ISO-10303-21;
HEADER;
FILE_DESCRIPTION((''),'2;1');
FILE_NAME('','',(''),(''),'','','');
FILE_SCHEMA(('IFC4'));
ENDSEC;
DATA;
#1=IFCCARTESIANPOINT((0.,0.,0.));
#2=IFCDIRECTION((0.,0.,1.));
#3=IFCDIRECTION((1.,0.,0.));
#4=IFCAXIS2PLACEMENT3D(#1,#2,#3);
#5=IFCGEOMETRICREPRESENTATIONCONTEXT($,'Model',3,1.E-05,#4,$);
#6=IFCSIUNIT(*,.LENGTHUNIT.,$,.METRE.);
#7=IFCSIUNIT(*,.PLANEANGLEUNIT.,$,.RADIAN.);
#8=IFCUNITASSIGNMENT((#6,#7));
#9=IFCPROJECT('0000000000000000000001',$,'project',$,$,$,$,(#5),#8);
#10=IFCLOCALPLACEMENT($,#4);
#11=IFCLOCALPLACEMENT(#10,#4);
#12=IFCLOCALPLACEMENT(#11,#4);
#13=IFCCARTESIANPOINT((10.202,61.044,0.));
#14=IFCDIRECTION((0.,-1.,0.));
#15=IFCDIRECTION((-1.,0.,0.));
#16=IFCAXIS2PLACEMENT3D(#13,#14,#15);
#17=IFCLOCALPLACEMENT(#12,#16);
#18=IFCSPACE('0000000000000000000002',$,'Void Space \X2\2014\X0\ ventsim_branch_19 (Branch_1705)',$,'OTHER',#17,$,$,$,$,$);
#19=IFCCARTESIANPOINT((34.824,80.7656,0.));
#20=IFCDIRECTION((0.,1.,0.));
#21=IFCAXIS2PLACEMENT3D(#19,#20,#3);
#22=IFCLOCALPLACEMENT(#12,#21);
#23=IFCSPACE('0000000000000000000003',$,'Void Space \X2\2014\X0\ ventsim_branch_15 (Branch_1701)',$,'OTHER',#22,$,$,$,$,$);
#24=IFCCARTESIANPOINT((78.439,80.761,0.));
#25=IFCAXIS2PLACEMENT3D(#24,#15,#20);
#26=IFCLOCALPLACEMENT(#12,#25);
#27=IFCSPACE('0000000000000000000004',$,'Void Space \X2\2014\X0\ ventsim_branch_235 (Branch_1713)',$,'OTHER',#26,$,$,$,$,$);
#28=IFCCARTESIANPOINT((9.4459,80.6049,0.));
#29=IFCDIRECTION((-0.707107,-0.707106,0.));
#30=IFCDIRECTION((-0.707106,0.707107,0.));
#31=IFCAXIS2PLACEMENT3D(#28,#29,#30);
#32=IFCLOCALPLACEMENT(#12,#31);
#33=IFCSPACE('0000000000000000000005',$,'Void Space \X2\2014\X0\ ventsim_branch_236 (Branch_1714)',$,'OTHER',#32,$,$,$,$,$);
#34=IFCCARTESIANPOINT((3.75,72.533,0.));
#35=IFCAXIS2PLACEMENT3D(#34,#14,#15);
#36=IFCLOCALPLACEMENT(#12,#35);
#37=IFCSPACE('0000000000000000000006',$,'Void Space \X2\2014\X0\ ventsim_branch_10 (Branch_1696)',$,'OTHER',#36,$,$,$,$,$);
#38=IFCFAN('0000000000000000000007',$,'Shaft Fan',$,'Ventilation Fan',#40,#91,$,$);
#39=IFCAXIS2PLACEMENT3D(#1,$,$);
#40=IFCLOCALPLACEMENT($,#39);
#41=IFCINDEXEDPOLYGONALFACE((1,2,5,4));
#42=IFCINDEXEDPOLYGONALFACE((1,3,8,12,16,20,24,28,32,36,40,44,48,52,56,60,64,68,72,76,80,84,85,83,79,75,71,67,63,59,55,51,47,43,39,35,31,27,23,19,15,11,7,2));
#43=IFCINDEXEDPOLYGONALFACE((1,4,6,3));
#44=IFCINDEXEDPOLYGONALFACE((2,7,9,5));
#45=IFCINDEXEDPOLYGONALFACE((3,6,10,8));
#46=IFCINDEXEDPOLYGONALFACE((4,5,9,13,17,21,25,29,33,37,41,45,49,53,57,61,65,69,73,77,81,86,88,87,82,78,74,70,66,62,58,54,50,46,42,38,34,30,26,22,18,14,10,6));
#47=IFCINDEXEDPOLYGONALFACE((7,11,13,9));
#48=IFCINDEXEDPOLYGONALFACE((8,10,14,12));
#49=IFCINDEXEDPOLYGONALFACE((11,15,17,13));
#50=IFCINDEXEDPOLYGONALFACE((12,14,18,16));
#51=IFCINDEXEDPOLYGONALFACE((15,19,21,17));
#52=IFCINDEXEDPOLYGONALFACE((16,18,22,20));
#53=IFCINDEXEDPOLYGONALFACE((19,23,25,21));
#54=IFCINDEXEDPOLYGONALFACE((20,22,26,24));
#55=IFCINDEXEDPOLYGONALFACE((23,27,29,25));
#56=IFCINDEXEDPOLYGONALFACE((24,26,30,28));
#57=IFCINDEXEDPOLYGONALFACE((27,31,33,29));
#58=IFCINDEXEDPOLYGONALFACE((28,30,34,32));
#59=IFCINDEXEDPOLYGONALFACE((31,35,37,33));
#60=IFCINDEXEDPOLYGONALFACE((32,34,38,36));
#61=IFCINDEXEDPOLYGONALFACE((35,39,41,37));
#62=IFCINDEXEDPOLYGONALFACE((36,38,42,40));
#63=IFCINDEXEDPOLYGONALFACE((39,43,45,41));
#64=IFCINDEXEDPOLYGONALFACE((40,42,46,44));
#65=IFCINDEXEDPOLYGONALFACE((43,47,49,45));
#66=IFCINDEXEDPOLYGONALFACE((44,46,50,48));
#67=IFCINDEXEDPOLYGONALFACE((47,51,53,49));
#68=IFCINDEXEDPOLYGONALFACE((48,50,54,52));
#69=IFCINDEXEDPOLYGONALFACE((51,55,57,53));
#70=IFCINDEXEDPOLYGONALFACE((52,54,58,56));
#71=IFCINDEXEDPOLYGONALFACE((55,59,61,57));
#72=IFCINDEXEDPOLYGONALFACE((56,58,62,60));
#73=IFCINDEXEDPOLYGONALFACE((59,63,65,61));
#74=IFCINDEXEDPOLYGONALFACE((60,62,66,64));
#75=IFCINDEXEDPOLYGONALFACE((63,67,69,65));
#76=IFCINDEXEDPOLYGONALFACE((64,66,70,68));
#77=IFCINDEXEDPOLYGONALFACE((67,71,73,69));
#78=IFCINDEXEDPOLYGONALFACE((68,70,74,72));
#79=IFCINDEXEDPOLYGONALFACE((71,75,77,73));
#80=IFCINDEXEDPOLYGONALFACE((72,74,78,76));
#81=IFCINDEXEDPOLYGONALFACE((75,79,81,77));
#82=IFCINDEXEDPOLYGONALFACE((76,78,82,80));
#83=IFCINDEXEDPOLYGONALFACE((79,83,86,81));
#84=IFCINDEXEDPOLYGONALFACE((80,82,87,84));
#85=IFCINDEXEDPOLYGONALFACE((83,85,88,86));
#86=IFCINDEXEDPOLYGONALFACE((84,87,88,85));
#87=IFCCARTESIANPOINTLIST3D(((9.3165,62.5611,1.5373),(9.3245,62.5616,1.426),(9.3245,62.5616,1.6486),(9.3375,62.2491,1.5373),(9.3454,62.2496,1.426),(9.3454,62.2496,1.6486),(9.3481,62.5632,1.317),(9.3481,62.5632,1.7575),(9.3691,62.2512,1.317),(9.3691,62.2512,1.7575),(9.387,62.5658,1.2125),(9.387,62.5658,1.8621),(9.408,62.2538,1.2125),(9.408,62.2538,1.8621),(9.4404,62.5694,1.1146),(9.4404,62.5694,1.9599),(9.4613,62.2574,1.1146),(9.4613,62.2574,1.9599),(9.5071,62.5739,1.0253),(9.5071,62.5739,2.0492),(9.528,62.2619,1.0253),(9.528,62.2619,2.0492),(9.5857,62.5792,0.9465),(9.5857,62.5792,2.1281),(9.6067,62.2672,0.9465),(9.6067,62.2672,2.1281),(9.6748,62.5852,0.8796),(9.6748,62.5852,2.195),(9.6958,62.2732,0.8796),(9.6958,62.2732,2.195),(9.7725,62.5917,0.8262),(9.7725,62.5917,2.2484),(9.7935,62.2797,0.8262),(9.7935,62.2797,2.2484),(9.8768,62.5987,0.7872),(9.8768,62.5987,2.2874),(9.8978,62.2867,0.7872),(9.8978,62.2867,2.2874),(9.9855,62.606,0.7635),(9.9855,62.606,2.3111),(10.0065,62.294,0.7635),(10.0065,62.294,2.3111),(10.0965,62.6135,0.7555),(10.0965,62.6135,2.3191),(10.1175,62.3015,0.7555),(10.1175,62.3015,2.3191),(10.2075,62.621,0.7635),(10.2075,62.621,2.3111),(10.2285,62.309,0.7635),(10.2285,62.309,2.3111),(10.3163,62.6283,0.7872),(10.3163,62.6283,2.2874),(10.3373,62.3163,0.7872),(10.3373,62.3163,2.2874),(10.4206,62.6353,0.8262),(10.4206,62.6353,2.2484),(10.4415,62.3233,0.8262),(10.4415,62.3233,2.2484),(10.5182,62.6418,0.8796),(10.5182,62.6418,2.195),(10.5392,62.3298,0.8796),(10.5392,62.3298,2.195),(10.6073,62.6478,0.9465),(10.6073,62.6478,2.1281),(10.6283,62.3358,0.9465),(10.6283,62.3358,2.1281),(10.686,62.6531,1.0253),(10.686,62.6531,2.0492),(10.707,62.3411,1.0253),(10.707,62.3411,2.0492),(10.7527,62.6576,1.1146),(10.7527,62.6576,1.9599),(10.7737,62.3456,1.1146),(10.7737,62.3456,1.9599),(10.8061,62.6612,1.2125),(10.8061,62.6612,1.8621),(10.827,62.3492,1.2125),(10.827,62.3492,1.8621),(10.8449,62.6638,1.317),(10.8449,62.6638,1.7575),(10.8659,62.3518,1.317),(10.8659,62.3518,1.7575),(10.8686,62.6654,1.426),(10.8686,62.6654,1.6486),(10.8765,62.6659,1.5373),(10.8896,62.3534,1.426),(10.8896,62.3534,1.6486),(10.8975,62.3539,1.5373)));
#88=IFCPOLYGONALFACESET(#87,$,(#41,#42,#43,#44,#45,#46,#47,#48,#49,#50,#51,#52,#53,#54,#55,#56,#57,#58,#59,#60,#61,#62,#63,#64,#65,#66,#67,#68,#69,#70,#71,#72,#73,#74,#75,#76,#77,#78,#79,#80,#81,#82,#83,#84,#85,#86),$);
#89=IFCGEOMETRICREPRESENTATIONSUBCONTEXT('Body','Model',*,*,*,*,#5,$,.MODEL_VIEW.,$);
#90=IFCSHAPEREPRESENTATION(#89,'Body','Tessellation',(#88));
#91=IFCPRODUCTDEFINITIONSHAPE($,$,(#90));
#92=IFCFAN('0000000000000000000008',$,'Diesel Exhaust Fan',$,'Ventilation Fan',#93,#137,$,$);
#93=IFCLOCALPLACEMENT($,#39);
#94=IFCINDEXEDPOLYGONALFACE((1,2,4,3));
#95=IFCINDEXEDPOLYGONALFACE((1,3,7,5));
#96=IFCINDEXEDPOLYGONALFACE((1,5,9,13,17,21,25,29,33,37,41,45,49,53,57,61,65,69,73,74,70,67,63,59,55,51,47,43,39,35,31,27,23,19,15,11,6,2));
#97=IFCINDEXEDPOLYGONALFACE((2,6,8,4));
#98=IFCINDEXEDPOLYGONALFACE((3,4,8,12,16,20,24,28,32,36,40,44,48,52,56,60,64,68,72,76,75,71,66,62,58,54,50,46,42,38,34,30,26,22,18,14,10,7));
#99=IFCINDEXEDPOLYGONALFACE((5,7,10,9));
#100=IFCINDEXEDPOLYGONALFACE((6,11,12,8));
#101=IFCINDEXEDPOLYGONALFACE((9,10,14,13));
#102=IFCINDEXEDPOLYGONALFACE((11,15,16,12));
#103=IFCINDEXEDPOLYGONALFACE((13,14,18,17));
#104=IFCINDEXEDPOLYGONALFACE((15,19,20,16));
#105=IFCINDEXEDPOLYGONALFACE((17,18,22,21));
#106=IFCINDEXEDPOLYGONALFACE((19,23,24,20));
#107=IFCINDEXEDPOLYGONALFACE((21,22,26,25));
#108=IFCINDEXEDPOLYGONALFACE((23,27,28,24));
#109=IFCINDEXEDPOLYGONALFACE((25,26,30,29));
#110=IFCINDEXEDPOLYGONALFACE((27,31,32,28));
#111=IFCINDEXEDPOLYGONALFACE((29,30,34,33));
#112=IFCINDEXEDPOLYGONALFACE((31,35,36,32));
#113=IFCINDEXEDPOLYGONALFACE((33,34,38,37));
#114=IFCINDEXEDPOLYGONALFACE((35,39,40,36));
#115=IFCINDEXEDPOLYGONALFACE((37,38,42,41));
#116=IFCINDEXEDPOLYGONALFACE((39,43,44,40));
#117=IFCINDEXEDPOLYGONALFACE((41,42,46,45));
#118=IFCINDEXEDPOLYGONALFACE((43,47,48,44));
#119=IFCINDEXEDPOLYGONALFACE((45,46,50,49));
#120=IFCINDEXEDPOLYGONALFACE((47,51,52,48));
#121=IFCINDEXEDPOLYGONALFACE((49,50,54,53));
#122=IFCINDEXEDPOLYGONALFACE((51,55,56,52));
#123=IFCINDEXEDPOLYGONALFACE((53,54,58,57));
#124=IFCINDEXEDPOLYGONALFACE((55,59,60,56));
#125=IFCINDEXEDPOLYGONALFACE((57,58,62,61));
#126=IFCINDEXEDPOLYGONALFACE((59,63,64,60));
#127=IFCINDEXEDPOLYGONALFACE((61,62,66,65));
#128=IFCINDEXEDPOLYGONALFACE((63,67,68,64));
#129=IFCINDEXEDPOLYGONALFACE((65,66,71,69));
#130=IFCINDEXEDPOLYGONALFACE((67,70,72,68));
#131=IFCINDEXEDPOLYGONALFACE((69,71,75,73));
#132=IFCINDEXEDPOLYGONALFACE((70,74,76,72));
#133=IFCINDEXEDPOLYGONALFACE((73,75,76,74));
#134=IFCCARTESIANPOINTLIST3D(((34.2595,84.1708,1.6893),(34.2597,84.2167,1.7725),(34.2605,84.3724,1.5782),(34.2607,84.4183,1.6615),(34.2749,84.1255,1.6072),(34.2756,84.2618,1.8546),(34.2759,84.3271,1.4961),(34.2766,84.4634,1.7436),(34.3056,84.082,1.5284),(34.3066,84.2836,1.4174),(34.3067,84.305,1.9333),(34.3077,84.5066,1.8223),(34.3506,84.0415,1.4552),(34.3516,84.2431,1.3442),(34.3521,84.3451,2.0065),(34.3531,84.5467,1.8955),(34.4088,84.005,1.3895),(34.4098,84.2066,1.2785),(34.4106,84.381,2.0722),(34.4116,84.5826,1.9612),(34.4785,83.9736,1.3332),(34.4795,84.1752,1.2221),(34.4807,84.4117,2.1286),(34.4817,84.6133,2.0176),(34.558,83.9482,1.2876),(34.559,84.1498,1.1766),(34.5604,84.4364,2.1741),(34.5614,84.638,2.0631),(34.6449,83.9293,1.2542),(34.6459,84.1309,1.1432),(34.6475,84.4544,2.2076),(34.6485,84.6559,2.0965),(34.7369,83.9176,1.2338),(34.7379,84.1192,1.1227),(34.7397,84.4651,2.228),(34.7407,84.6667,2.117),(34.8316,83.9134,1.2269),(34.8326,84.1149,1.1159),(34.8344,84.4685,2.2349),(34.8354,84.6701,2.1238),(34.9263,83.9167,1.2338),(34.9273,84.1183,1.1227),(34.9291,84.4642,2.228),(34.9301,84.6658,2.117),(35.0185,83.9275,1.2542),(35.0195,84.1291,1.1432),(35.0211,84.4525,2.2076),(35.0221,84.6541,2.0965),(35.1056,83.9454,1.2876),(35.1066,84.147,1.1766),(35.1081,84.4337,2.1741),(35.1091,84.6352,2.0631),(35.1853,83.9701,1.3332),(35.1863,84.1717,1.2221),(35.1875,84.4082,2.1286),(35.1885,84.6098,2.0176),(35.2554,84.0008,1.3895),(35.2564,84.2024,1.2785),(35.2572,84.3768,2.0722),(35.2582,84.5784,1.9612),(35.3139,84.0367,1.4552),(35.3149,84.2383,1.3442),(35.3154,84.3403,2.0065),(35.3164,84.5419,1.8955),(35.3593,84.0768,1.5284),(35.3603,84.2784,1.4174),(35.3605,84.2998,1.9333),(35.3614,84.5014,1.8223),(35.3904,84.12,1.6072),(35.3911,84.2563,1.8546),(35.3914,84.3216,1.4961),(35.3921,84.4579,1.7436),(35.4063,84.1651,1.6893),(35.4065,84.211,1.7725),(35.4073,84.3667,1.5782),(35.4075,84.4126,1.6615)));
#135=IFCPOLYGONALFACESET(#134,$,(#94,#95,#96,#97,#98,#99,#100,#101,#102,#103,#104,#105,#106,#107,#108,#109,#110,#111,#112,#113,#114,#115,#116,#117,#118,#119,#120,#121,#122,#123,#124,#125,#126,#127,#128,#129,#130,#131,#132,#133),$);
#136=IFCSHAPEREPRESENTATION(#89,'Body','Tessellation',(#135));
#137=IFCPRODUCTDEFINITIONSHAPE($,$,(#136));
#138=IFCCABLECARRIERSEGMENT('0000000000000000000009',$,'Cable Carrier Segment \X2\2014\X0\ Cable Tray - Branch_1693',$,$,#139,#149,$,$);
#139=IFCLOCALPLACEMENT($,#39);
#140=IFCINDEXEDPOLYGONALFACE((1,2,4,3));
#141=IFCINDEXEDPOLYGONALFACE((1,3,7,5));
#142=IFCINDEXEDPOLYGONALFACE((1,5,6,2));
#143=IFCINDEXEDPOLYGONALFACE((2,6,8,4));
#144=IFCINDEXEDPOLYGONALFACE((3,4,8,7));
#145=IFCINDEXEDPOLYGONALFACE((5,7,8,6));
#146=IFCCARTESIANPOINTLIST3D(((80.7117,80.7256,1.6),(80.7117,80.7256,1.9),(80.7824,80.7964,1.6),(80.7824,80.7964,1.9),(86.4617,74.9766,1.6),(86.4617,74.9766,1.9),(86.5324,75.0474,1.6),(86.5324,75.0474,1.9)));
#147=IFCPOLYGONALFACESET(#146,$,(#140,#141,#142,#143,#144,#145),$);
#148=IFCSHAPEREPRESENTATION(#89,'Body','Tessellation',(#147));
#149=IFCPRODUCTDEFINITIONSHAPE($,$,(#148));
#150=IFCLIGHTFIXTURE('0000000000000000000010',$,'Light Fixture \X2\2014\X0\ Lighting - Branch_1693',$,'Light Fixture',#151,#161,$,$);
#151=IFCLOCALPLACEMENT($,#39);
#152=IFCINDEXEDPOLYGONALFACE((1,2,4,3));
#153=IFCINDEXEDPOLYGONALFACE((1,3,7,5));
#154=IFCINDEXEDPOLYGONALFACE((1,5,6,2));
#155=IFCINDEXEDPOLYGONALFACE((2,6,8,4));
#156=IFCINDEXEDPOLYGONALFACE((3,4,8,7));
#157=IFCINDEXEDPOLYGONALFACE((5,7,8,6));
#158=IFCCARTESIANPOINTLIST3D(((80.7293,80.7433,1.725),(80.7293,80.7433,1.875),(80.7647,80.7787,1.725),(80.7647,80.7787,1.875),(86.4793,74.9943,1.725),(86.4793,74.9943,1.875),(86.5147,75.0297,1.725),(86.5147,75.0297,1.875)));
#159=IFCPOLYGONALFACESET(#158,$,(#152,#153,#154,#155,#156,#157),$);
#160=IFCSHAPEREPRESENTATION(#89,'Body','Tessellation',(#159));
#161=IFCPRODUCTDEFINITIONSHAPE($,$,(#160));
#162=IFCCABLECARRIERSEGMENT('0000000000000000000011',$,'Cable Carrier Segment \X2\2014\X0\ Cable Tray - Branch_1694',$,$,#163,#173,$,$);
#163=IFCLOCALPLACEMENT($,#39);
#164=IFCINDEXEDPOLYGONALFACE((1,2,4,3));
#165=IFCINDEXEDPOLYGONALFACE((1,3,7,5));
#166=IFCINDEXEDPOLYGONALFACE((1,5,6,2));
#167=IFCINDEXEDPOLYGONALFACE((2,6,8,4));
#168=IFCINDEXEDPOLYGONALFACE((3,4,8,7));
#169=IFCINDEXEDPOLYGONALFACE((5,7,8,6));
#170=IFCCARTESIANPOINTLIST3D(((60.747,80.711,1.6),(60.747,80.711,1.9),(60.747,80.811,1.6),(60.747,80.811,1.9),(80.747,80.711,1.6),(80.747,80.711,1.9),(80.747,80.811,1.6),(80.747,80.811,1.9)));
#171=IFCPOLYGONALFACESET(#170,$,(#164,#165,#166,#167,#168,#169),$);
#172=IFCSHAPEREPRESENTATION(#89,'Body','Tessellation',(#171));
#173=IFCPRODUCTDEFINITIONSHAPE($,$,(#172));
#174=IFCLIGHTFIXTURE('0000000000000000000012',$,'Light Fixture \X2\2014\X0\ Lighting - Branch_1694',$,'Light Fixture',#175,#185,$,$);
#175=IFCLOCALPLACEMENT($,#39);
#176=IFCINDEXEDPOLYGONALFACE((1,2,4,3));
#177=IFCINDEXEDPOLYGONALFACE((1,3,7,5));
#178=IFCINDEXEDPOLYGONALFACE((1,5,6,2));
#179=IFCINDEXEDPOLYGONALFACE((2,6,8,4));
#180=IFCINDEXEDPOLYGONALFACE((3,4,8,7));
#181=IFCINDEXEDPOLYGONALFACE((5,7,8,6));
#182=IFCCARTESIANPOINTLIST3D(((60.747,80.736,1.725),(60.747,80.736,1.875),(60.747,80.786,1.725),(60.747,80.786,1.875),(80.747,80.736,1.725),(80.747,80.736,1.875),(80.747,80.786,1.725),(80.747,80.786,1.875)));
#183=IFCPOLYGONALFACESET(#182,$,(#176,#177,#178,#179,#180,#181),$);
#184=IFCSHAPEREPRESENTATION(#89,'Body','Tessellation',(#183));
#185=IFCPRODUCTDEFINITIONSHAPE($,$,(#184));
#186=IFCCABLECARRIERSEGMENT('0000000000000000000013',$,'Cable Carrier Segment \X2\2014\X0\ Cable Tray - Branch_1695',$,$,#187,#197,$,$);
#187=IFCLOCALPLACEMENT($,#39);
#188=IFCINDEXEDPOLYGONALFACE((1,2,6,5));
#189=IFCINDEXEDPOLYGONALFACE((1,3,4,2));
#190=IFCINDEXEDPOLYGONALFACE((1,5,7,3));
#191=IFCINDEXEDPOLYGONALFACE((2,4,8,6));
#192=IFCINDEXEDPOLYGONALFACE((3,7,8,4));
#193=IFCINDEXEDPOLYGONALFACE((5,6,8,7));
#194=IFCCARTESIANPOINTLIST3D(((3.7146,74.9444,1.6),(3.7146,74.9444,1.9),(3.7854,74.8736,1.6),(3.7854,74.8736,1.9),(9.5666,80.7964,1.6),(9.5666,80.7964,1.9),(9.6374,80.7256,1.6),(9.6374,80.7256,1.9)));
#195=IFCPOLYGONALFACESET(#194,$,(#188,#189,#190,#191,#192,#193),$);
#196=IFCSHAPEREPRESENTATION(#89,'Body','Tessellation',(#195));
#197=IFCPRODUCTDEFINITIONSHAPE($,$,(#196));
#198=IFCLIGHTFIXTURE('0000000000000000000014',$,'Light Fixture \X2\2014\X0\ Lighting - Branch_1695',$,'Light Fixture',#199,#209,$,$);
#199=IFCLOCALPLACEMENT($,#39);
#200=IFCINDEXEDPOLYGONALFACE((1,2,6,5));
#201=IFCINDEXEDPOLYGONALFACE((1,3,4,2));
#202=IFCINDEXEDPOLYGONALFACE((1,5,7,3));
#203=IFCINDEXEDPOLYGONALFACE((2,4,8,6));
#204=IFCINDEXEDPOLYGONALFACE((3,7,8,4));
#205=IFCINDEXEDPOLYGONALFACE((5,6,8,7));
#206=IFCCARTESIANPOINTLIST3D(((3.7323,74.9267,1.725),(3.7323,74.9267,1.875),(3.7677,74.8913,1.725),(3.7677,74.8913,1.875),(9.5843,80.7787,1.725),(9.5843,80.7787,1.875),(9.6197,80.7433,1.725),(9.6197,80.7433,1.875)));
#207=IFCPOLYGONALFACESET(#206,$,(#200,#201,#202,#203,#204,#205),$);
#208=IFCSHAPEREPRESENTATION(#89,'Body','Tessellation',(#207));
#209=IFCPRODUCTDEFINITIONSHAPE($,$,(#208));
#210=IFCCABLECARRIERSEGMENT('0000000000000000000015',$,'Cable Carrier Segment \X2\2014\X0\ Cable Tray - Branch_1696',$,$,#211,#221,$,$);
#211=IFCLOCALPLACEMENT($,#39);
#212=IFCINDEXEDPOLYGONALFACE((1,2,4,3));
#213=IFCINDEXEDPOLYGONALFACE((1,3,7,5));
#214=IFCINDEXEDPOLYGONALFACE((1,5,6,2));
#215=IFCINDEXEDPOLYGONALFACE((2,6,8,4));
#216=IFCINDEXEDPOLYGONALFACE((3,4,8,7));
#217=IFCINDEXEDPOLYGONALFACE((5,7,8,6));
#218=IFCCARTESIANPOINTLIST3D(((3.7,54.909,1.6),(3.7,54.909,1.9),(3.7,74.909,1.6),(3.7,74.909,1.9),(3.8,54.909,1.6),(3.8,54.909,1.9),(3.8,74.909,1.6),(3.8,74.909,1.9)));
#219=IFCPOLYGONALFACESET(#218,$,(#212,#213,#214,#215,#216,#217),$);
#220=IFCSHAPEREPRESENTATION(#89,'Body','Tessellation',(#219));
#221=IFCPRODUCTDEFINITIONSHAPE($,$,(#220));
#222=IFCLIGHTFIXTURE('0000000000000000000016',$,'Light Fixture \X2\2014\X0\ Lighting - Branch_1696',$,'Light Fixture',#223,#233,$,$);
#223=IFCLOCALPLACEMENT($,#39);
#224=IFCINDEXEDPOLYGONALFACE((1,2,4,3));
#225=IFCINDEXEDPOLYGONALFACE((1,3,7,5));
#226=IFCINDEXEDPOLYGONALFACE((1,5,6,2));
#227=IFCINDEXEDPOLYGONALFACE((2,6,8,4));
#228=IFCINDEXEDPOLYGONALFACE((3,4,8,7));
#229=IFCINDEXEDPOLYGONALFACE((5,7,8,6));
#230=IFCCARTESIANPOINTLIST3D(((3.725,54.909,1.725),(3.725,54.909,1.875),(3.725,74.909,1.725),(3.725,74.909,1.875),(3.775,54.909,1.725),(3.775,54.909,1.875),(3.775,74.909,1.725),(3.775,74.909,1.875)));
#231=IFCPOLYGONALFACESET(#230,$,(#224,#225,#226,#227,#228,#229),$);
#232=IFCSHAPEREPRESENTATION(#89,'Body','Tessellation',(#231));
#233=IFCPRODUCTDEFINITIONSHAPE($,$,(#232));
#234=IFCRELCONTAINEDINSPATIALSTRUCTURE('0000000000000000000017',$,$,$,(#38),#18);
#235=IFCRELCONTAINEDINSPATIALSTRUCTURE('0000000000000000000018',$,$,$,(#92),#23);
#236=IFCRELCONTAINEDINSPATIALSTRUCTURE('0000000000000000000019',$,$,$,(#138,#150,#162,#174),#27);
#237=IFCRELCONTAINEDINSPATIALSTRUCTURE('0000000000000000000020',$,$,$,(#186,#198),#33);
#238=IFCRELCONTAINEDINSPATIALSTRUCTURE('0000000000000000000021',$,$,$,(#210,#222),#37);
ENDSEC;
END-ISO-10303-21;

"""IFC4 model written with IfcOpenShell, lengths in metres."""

from ifc_helpers import new_model, si_unit, frame, origin_with_axes, origin_2d_with_axis, place, context, subcontext, project, spatial, rectangle, circle, extrude, element, save


model = new_model("IFC4")

# Units and contexts
model_context = context("Model", 3, precision=1e-05, world=origin_with_axes())
body_context = subcontext(model_context, "Body", "Model", "MODEL_VIEW")
ifc_project = project(units=[si_unit("LENGTHUNIT", "METRE"), si_unit("PLANEANGLEUNIT", "RADIAN")], contexts=[model_context])

# Space
placement_1 = place(None, origin_with_axes())
placement_2 = place(placement_1, origin_with_axes())
placement_3 = place(placement_2, origin_with_axes())
space_1_placement = place(placement_3, frame((10.202, 61.044, 0.0), z_axis=(0.0, -1.0, 0.0), x_axis=(-1.0, 0.0, 0.0)))
space_1 = spatial("IfcSpace", at=space_1_placement, Name="Void Space — ventsim_branch_19 (Branch_1705)", ObjectType="OTHER")

# Fan
fan_1_placement = place(placement_3, frame((10.1175, 62.3015, 1.5373), z_axis=(-0.067045, 0.99775, 0.0), x_axis=(0.0, 0.0, 1.0)))
element("IfcFan", 1, at=fan_1_placement, inside=space_1, Name="Shaft Fan", ObjectType="Ventilation Fan", context=body_context, shape_type="SweptSolid", body=[
    extrude(circle(Radius=0.7818, at=origin_2d_with_axis()), origin_with_axes(), (0.0, 0.0, 1.0), 0.3127),
])

# Shared definitions
space_2_placement = place(placement_3, frame((34.824, 80.7656, 0.0), z_axis=(0.0, 1.0, 0.0), x_axis=(1.0, 0.0, 0.0)))
space_2 = spatial("IfcSpace", at=space_2_placement, Name="Void Space — ventsim_branch_15 (Branch_1701)", ObjectType="OTHER")

# Fan
fan_2_placement = place(placement_3, frame((34.834, 84.3925, 1.6199), z_axis=(-0.004342, -0.875935, 0.482409), x_axis=(0.002391, 0.482404, 0.875946)))
element("IfcFan", 2, at=fan_2_placement, inside=space_2, Name="Diesel Exhaust Fan", ObjectType="Ventilation Fan", context=body_context, shape_type="SweptSolid", body=[
    extrude(circle(Radius=0.5754, at=origin_2d_with_axis()), origin_with_axes(), (0.0, 0.0, 1.0), 0.2301),
])

# Shared definitions
space_3_placement = place(placement_3, frame((78.439, 80.761, 0.0), z_axis=(-1.0, 0.0, 0.0), x_axis=(0.0, 1.0, 0.0)))
space_3 = spatial("IfcSpace", at=space_3_placement, Name="Void Space — ventsim_branch_235 (Branch_1713)", ObjectType="OTHER")

# Cable carrier segment
cable_carrier_segment_1_placement = place(placement_3, frame((80.747, 80.761, 1.75), z_axis=(0.707168, -0.707045, 0.0), x_axis=(0.0, 0.0, 1.0)))
element("IfcCableCarrierSegment", 3, at=cable_carrier_segment_1_placement, inside=space_3, Name="Cable Carrier Segment — Cable Tray - Branch_1693", context=body_context, shape_type="SweptSolid", body=[
    extrude(rectangle(XDim=0.3, YDim=0.1, at=origin_2d_with_axis()), origin_with_axes(), (0.0, 0.0, 1.0), 8.131),
])

# Light fixture
light_fixture_1_placement = place(placement_3, frame((80.747, 80.761, 1.8), z_axis=(0.707168, -0.707045, 0.0), x_axis=(0.0, 0.0, 1.0)))
element("IfcLightFixture", 4, at=light_fixture_1_placement, inside=space_3, Name="Light Fixture — Lighting - Branch_1693", ObjectType="Light Fixture", context=body_context, shape_type="SweptSolid", body=[
    extrude(rectangle(XDim=0.15, YDim=0.05, at=origin_2d_with_axis()), origin_with_axes(), (0.0, 0.0, 1.0), 8.131),
])

# Cable carrier segment
cable_carrier_segment_2_placement = place(placement_3, frame((80.747, 80.761, 1.75), z_axis=(-1.0, 0.0, 0.0), x_axis=(0.0, 0.0, 1.0)))
element("IfcCableCarrierSegment", 5, at=cable_carrier_segment_2_placement, inside=space_3, Name="Cable Carrier Segment — Cable Tray - Branch_1694", context=body_context, shape_type="SweptSolid", body=[
    extrude(rectangle(XDim=0.3, YDim=0.1, at=origin_2d_with_axis()), origin_with_axes(), (0.0, 0.0, 1.0), 20.0),
])

# Light fixture
light_fixture_2_placement = place(placement_3, frame((80.747, 80.761, 1.8), z_axis=(-1.0, 0.0, 0.0), x_axis=(0.0, 0.0, 1.0)))
element("IfcLightFixture", 6, at=light_fixture_2_placement, inside=space_3, Name="Light Fixture — Lighting - Branch_1694", ObjectType="Light Fixture", context=body_context, shape_type="SweptSolid", body=[
    extrude(rectangle(XDim=0.15, YDim=0.05, at=origin_2d_with_axis()), origin_with_axes(), (0.0, 0.0, 1.0), 20.0),
])

# Shared definitions
space_4_placement = place(placement_3, frame((9.4459, 80.6049, 0.0), z_axis=(-0.707107, -0.707106, 0.0), x_axis=(-0.707106, 0.707107, 0.0)))
space_4 = spatial("IfcSpace", at=space_4_placement, Name="Void Space — ventsim_branch_236 (Branch_1714)", ObjectType="OTHER")

# Cable carrier segment
cable_carrier_segment_3_placement = place(placement_3, frame((9.602, 80.761, 1.75), z_axis=(-0.707107, -0.707106, 0.0), x_axis=(0.0, 0.0, 1.0)))
element("IfcCableCarrierSegment", 7, at=cable_carrier_segment_3_placement, inside=space_4, Name="Cable Carrier Segment — Cable Tray - Branch_1695", context=body_context, shape_type="SweptSolid", body=[
    extrude(rectangle(XDim=0.3, YDim=0.1, at=origin_2d_with_axis()), origin_with_axes(), (0.0, 0.0, 1.0), 8.276),
])

# Light fixture
light_fixture_3_placement = place(placement_3, frame((9.602, 80.761, 1.8), z_axis=(-0.707107, -0.707106, 0.0), x_axis=(0.0, 0.0, 1.0)))
element("IfcLightFixture", 8, at=light_fixture_3_placement, inside=space_4, Name="Light Fixture — Lighting - Branch_1695", ObjectType="Light Fixture", context=body_context, shape_type="SweptSolid", body=[
    extrude(rectangle(XDim=0.15, YDim=0.05, at=origin_2d_with_axis()), origin_with_axes(), (0.0, 0.0, 1.0), 8.276),
])

# Shared definitions
space_5_placement = place(placement_3, frame((3.75, 72.533, 0.0), z_axis=(0.0, -1.0, 0.0), x_axis=(-1.0, 0.0, 0.0)))
space_5 = spatial("IfcSpace", at=space_5_placement, Name="Void Space — ventsim_branch_10 (Branch_1696)", ObjectType="OTHER")

# Cable carrier segment
cable_carrier_segment_4_placement = place(placement_3, frame((3.75, 74.909, 1.75), z_axis=(0.0, -1.0, 0.0), x_axis=(0.0, 0.0, 1.0)))
element("IfcCableCarrierSegment", 9, at=cable_carrier_segment_4_placement, inside=space_5, Name="Cable Carrier Segment — Cable Tray - Branch_1696", context=body_context, shape_type="SweptSolid", body=[
    extrude(rectangle(XDim=0.3, YDim=0.1, at=origin_2d_with_axis()), origin_with_axes(), (0.0, 0.0, 1.0), 20.0),
])

# Light fixture
light_fixture_4_placement = place(placement_3, frame((3.75, 74.909, 1.8), z_axis=(0.0, -1.0, 0.0), x_axis=(0.0, 0.0, 1.0)))
element("IfcLightFixture", 10, at=light_fixture_4_placement, inside=space_5, Name="Light Fixture — Lighting - Branch_1696", ObjectType="Light Fixture", context=body_context, shape_type="SweptSolid", body=[
    extrude(rectangle(XDim=0.15, YDim=0.05, at=origin_2d_with_axis()), origin_with_axes(), (0.0, 0.0, 1.0), 20.0),
])

save(model, "model.ifc")
